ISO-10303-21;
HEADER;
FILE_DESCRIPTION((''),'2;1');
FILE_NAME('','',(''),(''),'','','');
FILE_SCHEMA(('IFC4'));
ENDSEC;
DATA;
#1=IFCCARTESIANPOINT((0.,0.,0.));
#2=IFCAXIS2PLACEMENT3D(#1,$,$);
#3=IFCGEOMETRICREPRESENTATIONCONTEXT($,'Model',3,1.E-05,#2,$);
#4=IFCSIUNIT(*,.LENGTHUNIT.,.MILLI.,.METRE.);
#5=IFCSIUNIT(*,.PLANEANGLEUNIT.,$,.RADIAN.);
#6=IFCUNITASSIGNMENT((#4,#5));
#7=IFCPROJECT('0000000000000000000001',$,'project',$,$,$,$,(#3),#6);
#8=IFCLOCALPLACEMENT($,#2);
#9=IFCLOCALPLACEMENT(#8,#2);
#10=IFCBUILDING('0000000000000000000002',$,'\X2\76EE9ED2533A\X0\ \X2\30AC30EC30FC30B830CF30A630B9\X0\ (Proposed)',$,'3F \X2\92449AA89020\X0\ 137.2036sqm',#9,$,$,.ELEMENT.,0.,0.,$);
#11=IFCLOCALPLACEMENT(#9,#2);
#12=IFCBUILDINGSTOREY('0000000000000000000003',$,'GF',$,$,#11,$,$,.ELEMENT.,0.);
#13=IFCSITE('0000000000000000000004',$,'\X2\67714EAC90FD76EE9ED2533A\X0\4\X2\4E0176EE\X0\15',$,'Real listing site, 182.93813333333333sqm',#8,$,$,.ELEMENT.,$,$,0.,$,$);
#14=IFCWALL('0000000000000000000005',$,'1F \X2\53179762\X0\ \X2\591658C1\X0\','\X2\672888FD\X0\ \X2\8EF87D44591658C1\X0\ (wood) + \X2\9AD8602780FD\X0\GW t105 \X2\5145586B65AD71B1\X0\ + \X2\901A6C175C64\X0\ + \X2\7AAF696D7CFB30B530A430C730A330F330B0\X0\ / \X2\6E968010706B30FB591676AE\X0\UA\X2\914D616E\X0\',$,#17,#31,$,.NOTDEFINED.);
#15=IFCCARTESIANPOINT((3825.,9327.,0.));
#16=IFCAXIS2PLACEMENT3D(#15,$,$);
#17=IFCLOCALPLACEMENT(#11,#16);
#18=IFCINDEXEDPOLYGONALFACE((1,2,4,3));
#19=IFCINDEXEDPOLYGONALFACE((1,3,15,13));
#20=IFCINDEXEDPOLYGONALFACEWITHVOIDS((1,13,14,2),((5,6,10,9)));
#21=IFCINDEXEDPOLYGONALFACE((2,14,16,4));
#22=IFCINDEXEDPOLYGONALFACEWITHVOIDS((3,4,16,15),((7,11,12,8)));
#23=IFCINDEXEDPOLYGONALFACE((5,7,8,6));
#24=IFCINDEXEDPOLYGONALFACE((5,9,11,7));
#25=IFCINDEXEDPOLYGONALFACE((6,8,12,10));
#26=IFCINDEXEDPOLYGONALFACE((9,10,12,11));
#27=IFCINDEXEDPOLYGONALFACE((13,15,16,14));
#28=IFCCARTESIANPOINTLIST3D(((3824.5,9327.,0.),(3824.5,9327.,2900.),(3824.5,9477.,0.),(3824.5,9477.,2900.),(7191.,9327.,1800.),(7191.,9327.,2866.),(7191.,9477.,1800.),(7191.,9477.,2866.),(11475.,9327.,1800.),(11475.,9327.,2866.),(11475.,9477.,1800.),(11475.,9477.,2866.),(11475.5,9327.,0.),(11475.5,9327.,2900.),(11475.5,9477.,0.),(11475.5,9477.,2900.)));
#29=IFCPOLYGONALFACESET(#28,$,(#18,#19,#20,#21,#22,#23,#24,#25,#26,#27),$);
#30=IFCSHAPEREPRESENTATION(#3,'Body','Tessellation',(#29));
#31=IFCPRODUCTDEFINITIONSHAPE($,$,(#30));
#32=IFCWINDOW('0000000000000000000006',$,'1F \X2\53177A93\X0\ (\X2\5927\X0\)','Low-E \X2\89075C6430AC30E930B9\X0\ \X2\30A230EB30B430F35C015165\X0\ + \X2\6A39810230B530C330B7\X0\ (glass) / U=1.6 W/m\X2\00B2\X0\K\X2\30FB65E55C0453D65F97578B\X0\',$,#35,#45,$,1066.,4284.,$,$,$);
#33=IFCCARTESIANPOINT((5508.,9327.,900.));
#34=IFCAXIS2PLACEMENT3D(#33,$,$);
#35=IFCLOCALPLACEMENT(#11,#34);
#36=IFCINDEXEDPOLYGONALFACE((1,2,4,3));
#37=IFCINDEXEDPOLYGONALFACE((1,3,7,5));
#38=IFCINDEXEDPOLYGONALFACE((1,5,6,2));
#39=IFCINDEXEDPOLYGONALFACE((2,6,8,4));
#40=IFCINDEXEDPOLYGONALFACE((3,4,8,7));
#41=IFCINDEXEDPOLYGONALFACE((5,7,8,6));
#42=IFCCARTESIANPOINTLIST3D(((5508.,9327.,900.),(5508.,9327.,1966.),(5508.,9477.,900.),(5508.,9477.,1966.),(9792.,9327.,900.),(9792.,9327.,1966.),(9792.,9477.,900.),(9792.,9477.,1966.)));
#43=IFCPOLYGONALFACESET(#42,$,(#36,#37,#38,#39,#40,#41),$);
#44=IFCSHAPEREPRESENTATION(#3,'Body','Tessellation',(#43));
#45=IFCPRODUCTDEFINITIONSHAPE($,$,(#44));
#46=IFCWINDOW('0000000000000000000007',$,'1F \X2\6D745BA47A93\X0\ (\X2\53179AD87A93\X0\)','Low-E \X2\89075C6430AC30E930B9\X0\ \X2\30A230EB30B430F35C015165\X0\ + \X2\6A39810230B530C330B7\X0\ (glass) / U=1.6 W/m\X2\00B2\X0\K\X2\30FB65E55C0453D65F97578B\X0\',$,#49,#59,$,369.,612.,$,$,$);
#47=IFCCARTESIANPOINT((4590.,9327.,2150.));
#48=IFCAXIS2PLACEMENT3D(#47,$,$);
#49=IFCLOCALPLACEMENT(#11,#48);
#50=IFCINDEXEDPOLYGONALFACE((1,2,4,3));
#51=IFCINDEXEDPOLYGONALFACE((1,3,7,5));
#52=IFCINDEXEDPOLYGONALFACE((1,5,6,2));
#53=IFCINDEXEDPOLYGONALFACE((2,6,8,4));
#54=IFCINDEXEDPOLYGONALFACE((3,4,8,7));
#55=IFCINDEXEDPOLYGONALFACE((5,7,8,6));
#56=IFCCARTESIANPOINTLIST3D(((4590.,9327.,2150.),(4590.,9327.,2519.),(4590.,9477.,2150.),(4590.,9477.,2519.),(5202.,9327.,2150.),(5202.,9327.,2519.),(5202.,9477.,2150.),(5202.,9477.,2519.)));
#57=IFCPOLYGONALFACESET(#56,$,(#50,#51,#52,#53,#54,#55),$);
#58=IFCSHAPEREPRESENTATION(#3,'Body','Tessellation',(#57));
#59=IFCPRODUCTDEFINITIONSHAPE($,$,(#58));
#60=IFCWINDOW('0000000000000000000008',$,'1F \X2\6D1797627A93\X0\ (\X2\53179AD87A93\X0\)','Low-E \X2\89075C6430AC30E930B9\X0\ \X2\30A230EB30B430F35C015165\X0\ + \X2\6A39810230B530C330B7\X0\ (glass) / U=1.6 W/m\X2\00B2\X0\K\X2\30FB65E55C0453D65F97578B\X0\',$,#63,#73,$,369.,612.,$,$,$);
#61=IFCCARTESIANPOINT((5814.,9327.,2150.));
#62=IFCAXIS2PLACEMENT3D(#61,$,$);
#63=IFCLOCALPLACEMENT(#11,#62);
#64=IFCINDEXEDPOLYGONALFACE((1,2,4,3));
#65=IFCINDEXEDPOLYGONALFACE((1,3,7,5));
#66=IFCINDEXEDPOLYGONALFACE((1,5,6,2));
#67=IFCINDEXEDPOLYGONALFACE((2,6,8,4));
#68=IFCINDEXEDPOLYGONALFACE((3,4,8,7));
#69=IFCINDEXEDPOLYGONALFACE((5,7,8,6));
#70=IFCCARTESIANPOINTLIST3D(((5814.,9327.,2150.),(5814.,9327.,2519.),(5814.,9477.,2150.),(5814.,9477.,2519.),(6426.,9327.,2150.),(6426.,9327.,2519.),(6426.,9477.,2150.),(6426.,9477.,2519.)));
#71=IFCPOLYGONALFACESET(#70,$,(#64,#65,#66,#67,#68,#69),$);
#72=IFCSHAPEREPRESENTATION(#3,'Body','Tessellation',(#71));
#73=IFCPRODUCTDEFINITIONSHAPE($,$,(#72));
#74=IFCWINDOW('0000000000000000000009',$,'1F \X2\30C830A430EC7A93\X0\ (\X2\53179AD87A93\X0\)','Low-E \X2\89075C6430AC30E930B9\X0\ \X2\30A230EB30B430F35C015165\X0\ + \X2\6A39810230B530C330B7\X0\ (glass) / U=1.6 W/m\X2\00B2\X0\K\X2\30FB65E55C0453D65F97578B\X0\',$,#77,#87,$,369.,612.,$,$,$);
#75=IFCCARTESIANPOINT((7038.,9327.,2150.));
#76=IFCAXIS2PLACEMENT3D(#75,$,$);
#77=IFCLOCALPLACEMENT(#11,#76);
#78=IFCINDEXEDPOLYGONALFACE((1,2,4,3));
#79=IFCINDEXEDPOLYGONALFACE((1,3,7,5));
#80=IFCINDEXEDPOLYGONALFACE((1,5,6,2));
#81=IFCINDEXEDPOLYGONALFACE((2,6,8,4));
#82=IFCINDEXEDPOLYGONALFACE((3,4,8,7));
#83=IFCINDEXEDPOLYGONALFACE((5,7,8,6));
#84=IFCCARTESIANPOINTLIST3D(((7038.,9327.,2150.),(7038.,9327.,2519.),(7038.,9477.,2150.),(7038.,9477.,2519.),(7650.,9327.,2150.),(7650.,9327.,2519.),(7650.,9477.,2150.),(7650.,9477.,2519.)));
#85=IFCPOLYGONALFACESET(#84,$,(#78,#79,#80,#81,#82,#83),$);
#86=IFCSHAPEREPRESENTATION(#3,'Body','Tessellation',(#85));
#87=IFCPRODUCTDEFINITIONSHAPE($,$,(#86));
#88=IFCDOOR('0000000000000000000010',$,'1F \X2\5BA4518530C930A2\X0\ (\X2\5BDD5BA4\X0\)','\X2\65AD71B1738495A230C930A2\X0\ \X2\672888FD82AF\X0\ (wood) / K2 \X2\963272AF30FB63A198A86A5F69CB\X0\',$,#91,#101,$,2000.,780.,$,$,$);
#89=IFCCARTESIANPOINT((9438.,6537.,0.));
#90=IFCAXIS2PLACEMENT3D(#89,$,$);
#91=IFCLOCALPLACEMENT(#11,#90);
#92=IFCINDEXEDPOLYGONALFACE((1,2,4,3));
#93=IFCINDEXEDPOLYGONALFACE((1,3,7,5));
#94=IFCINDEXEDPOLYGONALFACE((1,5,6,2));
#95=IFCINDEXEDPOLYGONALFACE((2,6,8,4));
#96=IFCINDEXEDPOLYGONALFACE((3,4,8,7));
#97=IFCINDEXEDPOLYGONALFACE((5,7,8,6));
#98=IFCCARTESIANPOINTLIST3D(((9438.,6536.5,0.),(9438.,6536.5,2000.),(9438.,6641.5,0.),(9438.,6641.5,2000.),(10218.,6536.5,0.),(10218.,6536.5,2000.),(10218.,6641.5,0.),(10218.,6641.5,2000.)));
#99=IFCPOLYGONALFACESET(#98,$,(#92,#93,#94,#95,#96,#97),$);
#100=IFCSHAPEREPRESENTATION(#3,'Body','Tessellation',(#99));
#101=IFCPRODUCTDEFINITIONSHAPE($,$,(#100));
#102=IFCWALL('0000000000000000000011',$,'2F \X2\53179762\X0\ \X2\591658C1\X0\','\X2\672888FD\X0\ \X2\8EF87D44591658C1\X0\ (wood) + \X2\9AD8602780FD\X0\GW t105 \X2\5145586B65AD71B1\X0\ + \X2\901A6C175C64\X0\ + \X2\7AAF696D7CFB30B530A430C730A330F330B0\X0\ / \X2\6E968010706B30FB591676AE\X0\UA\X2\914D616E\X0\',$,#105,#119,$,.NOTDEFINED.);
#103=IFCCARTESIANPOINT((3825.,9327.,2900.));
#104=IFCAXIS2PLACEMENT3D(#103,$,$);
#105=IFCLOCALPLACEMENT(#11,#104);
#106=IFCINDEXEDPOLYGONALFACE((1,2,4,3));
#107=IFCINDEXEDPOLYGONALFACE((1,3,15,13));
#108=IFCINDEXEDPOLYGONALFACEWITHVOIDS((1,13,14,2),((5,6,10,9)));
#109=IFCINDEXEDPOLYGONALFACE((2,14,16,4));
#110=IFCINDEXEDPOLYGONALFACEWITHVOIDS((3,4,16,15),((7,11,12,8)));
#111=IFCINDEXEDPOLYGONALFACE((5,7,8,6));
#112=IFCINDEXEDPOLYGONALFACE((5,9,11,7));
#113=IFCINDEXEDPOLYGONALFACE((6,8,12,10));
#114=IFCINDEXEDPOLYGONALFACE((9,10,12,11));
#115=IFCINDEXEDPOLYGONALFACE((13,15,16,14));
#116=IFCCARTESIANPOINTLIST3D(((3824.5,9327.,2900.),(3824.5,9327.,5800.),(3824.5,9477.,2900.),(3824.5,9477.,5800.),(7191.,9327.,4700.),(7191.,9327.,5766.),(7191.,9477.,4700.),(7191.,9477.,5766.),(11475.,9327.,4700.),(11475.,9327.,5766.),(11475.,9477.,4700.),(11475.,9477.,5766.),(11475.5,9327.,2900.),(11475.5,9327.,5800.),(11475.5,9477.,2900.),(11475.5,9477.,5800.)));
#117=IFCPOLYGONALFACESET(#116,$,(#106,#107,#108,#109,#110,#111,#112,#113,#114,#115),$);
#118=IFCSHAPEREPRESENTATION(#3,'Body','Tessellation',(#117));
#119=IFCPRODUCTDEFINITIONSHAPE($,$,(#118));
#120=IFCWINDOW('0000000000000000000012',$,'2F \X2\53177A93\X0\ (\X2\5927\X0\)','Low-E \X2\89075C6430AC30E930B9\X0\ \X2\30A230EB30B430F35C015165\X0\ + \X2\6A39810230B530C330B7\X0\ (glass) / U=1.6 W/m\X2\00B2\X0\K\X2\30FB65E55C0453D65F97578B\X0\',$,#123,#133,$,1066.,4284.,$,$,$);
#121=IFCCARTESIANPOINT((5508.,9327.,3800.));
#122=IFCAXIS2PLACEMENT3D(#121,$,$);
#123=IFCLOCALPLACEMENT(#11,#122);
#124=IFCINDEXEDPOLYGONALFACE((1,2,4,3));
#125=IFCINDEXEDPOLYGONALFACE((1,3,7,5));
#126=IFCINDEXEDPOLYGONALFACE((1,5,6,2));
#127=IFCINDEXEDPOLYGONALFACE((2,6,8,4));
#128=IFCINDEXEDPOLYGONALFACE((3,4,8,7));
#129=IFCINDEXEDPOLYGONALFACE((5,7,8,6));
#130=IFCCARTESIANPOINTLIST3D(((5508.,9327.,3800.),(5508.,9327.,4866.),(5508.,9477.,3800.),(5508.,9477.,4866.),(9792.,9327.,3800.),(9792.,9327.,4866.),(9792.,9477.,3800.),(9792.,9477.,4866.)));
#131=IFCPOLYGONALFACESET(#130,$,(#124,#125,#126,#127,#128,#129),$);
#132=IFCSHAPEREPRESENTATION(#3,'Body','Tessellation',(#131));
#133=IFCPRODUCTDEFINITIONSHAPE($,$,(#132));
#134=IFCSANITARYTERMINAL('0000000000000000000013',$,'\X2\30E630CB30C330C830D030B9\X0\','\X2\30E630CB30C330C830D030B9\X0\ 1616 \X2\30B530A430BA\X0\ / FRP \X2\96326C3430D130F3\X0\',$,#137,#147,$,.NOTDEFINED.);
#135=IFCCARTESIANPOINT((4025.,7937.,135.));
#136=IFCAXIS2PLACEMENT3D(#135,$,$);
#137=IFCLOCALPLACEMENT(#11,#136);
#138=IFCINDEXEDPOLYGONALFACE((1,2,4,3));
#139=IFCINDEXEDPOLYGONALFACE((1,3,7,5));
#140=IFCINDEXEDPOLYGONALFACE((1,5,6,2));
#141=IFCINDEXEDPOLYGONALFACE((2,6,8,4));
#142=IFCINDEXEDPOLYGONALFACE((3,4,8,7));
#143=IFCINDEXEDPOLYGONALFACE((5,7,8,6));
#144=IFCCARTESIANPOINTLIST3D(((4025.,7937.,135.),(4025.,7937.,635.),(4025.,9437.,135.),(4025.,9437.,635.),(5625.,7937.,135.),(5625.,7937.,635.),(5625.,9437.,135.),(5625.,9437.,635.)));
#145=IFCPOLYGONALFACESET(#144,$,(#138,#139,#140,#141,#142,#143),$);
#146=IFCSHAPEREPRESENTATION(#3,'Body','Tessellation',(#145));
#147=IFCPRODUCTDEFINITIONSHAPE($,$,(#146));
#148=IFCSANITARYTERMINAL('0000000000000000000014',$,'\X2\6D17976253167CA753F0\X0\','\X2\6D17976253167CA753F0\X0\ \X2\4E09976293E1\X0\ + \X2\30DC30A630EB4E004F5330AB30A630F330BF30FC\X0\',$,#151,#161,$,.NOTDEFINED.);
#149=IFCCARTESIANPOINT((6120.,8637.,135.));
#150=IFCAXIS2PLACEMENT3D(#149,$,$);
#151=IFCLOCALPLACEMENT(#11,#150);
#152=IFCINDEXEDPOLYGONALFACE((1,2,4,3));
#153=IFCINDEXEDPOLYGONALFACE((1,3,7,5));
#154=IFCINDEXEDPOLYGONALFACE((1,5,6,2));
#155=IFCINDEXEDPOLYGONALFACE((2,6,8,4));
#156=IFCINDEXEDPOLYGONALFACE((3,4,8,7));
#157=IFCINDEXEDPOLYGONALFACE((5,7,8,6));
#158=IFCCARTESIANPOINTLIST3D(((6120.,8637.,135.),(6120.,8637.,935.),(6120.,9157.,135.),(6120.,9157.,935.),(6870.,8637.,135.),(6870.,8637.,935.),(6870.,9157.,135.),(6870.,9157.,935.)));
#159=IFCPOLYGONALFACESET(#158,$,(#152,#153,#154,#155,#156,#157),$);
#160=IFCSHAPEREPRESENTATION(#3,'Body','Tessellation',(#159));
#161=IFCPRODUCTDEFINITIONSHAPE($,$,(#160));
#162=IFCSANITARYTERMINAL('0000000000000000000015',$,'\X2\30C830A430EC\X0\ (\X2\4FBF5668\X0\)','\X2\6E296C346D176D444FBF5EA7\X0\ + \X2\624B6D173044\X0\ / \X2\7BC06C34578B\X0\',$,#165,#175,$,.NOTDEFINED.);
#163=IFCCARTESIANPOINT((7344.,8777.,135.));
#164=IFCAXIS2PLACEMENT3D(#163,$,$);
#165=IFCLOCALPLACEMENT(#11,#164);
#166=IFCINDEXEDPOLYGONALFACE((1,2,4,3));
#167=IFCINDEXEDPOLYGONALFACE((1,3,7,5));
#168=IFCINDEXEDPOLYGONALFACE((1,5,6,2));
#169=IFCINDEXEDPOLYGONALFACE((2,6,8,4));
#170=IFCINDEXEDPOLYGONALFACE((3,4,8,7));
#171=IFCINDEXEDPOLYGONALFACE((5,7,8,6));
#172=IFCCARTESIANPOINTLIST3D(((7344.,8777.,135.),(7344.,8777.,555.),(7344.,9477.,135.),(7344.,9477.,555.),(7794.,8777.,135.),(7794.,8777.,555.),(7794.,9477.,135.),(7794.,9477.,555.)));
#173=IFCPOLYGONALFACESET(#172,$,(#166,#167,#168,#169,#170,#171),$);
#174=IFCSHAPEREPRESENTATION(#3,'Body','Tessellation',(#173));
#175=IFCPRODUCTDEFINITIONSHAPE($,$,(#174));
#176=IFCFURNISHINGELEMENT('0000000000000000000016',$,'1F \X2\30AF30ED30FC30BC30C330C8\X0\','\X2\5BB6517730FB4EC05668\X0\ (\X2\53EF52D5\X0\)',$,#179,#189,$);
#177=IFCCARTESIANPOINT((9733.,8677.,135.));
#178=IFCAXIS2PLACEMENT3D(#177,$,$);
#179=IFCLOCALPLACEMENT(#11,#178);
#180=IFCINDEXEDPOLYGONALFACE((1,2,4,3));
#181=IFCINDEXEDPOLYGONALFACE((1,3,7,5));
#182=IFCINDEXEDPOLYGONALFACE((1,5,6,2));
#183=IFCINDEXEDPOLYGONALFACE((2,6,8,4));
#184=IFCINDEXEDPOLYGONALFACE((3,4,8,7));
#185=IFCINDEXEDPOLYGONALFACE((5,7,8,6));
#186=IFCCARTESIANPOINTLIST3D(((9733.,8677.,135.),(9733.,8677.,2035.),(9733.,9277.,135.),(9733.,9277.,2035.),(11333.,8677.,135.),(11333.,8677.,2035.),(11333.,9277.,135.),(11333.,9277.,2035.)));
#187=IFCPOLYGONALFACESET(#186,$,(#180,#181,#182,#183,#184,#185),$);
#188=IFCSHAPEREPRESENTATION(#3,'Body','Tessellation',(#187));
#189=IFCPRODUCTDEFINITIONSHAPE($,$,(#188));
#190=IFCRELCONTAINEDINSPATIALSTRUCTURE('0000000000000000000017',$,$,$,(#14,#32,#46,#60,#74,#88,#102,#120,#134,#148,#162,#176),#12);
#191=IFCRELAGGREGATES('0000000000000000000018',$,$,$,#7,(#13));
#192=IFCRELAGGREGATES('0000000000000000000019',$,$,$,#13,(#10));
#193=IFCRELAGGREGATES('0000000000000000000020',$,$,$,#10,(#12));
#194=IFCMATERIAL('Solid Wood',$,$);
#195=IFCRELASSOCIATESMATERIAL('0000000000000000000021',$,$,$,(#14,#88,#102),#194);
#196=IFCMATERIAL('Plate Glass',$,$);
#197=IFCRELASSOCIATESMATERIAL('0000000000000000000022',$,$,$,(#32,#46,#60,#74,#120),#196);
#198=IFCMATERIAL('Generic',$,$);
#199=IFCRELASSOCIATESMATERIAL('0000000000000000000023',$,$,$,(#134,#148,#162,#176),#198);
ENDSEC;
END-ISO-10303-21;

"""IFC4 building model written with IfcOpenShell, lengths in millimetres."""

from ifc_helpers import new_model, si_unit, frame, frame_2d, origin, place, context, project, spatial, rectangle, extrude, material, element, fill, save


model = new_model("IFC4")

# Units and contexts
model_context = context("Model", 3, precision=1e-05, world=origin())
ifc_project = project(units=[si_unit("LENGTHUNIT", "METRE", prefix="MILLI"), si_unit("PLANEANGLEUNIT", "RADIAN")], contexts=[model_context])

# Site, building, storey
site_placement = place(None, origin())
site = spatial("IfcSite", under=ifc_project, at=site_placement, Name="東京都目黒区4丁目15", ObjectType="Real listing site, 182.93813333333333sqm", CompositionType="ELEMENT", RefElevation=0.0)
building_placement = place(site_placement, origin())
building = spatial("IfcBuilding", under=site, at=building_placement, Name="目黒区 ガレージハウス (Proposed)", ObjectType="3F 鉄骨造 137.2036sqm", CompositionType="ELEMENT", ElevationOfRefHeight=0.0, ElevationOfTerrain=0.0)
storey_placement = place(building_placement, origin())
storey = spatial("IfcBuildingStorey", under=building, at=storey_placement, Name="GF", CompositionType="ELEMENT", Elevation=0.0)

# Wall, openings, windows
ifc_material_1 = material(Name="Solid Wood")
wall_1_placement = place(storey_placement, frame((3825.0, 9327.0, 0.0)))
wall_1 = element("IfcWall", 1, at=wall_1_placement, inside=storey, material=ifc_material_1, Name="1F 北面 外壁", Description="木製 軸組外壁 (wood) + 高性能GW t105 充填断熱 + 通気層 + 窯業系サイディング / 準耐火・外皮UA配慮", PredefinedType="NOTDEFINED", context=model_context, shape_type="SweptSolid", body=[
    extrude(rectangle(XDim=7651.0, YDim=150.0, at=frame_2d((3825.0, 75.0))), frame((3825.0, 9327.0, 0.0)), (0.0, 0.0, 1.0), 2900.0),
])
opening_1_placement = place(storey_placement, frame((5508.0, 9327.0, 900.0)))
opening_1 = element("IfcOpeningElement", 2, at=opening_1_placement, cuts=wall_1, PredefinedType="NOTDEFINED", context=model_context, shape_type="SweptSolid", body=[
    extrude(rectangle(XDim=4284.0, YDim=150.0, at=frame_2d((2142.0, 75.0))), frame((5508.0, 9327.0, 900.0)), (0.0, 0.0, 1.0), 1066.0),
])
opening_2_placement = place(storey_placement, frame((4590.0, 9327.0, 2150.0)))
opening_2 = element("IfcOpeningElement", 3, at=opening_2_placement, cuts=wall_1, PredefinedType="NOTDEFINED", context=model_context, shape_type="SweptSolid", body=[
    extrude(rectangle(XDim=612.0, YDim=150.0, at=frame_2d((306.0, 75.0))), frame((4590.0, 9327.0, 2150.0)), (0.0, 0.0, 1.0), 369.0),
])
opening_3_placement = place(storey_placement, frame((5814.0, 9327.0, 2150.0)))
opening_3 = element("IfcOpeningElement", 4, at=opening_3_placement, cuts=wall_1, PredefinedType="NOTDEFINED", context=model_context, shape_type="SweptSolid", body=[
    extrude(rectangle(XDim=612.0, YDim=150.0, at=frame_2d((306.0, 75.0))), frame((5814.0, 9327.0, 2150.0)), (0.0, 0.0, 1.0), 369.0),
])
opening_4_placement = place(storey_placement, frame((7038.0, 9327.0, 2150.0)))
opening_4 = element("IfcOpeningElement", 5, at=opening_4_placement, cuts=wall_1, PredefinedType="NOTDEFINED", context=model_context, shape_type="SweptSolid", body=[
    extrude(rectangle(XDim=612.0, YDim=150.0, at=frame_2d((306.0, 75.0))), frame((7038.0, 9327.0, 2150.0)), (0.0, 0.0, 1.0), 369.0),
])
ifc_material_2 = material(Name="Plate Glass")
window_1_placement = place(storey_placement, frame((5508.0, 9327.0, 900.0)))
window_1 = element("IfcWindow", 6, at=window_1_placement, inside=storey, material=ifc_material_2, Name="1F 北窓 (大)", Description="Low-E 複層ガラス アルゴン封入 + 樹脂サッシ (glass) / U=1.6 W/m²K・日射取得型", OverallHeight=1066.0, OverallWidth=4284.0, context=model_context, shape_type="SweptSolid", body=[
    extrude(rectangle(XDim=4284.0, YDim=150.0, at=frame_2d((2142.0, 75.0))), frame((5508.0, 9327.0, 900.0)), (0.0, 0.0, 1.0), 1066.0),
])
fill(opening_1, window_1)
window_2_placement = place(storey_placement, frame((4590.0, 9327.0, 2150.0)))
window_2 = element("IfcWindow", 7, at=window_2_placement, inside=storey, material=ifc_material_2, Name="1F 浴室窓 (北高窓)", Description="Low-E 複層ガラス アルゴン封入 + 樹脂サッシ (glass) / U=1.6 W/m²K・日射取得型", OverallHeight=369.0, OverallWidth=612.0, context=model_context, shape_type="SweptSolid", body=[
    extrude(rectangle(XDim=612.0, YDim=150.0, at=frame_2d((306.0, 75.0))), frame((4590.0, 9327.0, 2150.0)), (0.0, 0.0, 1.0), 369.0),
])
fill(opening_2, window_2)
window_3_placement = place(storey_placement, frame((5814.0, 9327.0, 2150.0)))
window_3 = element("IfcWindow", 8, at=window_3_placement, inside=storey, material=ifc_material_2, Name="1F 洗面窓 (北高窓)", Description="Low-E 複層ガラス アルゴン封入 + 樹脂サッシ (glass) / U=1.6 W/m²K・日射取得型", OverallHeight=369.0, OverallWidth=612.0, context=model_context, shape_type="SweptSolid", body=[
    extrude(rectangle(XDim=612.0, YDim=150.0, at=frame_2d((306.0, 75.0))), frame((5814.0, 9327.0, 2150.0)), (0.0, 0.0, 1.0), 369.0),
])
fill(opening_3, window_3)
window_4_placement = place(storey_placement, frame((7038.0, 9327.0, 2150.0)))
window_4 = element("IfcWindow", 9, at=window_4_placement, inside=storey, material=ifc_material_2, Name="1F トイレ窓 (北高窓)", Description="Low-E 複層ガラス アルゴン封入 + 樹脂サッシ (glass) / U=1.6 W/m²K・日射取得型", OverallHeight=369.0, OverallWidth=612.0, context=model_context, shape_type="SweptSolid", body=[
    extrude(rectangle(XDim=612.0, YDim=150.0, at=frame_2d((306.0, 75.0))), frame((7038.0, 9327.0, 2150.0)), (0.0, 0.0, 1.0), 369.0),
])
fill(opening_4, window_4)

# Door
door_1_placement = place(storey_placement, frame((9438.0, 6537.0, 0.0)))
element("IfcDoor", 10, at=door_1_placement, inside=storey, material=ifc_material_1, Name="1F 室内ドア (寝室)", Description="断熱玄関ドア 木製芯 (wood) / K2 防犯・採風機構", OverallHeight=2000.0, OverallWidth=780.0, context=model_context, shape_type="SweptSolid", body=[
    extrude(rectangle(XDim=780.0, YDim=105.0, at=frame_2d((390.0, 52.0))), frame((9438.0, 6537.0, 0.0)), (0.0, 0.0, 1.0), 2000.0),
])

# Wall, opening, window
wall_2_placement = place(storey_placement, frame((3825.0, 9327.0, 2900.0)))
wall_2 = element("IfcWall", 11, at=wall_2_placement, inside=storey, material=ifc_material_1, Name="2F 北面 外壁", Description="木製 軸組外壁 (wood) + 高性能GW t105 充填断熱 + 通気層 + 窯業系サイディング / 準耐火・外皮UA配慮", PredefinedType="NOTDEFINED", context=model_context, shape_type="SweptSolid", body=[
    extrude(rectangle(XDim=7651.0, YDim=150.0, at=frame_2d((3825.0, 75.0))), frame((3825.0, 9327.0, 2900.0)), (0.0, 0.0, 1.0), 2900.0),
])
opening_5_placement = place(storey_placement, frame((5508.0, 9327.0, 3800.0)))
opening_5 = element("IfcOpeningElement", 12, at=opening_5_placement, cuts=wall_2, PredefinedType="NOTDEFINED", context=model_context, shape_type="SweptSolid", body=[
    extrude(rectangle(XDim=4284.0, YDim=150.0, at=frame_2d((2142.0, 75.0))), frame((5508.0, 9327.0, 3800.0)), (0.0, 0.0, 1.0), 1066.0),
])
window_5_placement = place(storey_placement, frame((5508.0, 9327.0, 3800.0)))
window_5 = element("IfcWindow", 13, at=window_5_placement, inside=storey, material=ifc_material_2, Name="2F 北窓 (大)", Description="Low-E 複層ガラス アルゴン封入 + 樹脂サッシ (glass) / U=1.6 W/m²K・日射取得型", OverallHeight=1066.0, OverallWidth=4284.0, context=model_context, shape_type="SweptSolid", body=[
    extrude(rectangle(XDim=4284.0, YDim=150.0, at=frame_2d((2142.0, 75.0))), frame((5508.0, 9327.0, 3800.0)), (0.0, 0.0, 1.0), 1066.0),
])
fill(opening_5, window_5)

# Sanitary terminals
ifc_material_3 = material(Name="Generic")
sanitary_terminal_1_placement = place(storey_placement, frame((4025.0, 7937.0, 135.0)))
element("IfcSanitaryTerminal", 14, at=sanitary_terminal_1_placement, inside=storey, material=ifc_material_3, Name="ユニットバス", Description="ユニットバス 1616 サイズ / FRP 防水パン", PredefinedType="NOTDEFINED", context=model_context, shape_type="SweptSolid", body=[
    extrude(rectangle(XDim=1600.0, YDim=1500.0, at=frame_2d((800.0, 750.0))), frame((4025.0, 7937.0, 135.0)), (0.0, 0.0, 1.0), 500.0),
])
sanitary_terminal_2_placement = place(storey_placement, frame((6120.0, 8637.0, 135.0)))
element("IfcSanitaryTerminal", 15, at=sanitary_terminal_2_placement, inside=storey, material=ifc_material_3, Name="洗面化粧台", Description="洗面化粧台 三面鏡 + ボウル一体カウンター", PredefinedType="NOTDEFINED", context=model_context, shape_type="SweptSolid", body=[
    extrude(rectangle(XDim=750.0, YDim=520.0, at=frame_2d((375.0, 260.0))), frame((6120.0, 8637.0, 135.0)), (0.0, 0.0, 1.0), 800.0),
])
sanitary_terminal_3_placement = place(storey_placement, frame((7344.0, 8777.0, 135.0)))
element("IfcSanitaryTerminal", 16, at=sanitary_terminal_3_placement, inside=storey, material=ifc_material_3, Name="トイレ (便器)", Description="温水洗浄便座 + 手洗い / 節水型", PredefinedType="NOTDEFINED", context=model_context, shape_type="SweptSolid", body=[
    extrude(rectangle(XDim=450.0, YDim=700.0, at=frame_2d((225.0, 350.0))), frame((7344.0, 8777.0, 135.0)), (0.0, 0.0, 1.0), 420.0),
])

# Furnishing element
furnishing_1_placement = place(storey_placement, frame((9733.0, 8677.0, 135.0)))
element("IfcFurnishingElement", 17, at=furnishing_1_placement, inside=storey, material=ifc_material_3, Name="1F クローゼット", Description="家具・什器 (可動)", context=model_context, shape_type="SweptSolid", body=[
    extrude(rectangle(XDim=1600.0, YDim=600.0, at=frame_2d((800.0, 300.0))), frame((9733.0, 8677.0, 135.0)), (0.0, 0.0, 1.0), 1900.0),
])

save(model, "model.ifc")
